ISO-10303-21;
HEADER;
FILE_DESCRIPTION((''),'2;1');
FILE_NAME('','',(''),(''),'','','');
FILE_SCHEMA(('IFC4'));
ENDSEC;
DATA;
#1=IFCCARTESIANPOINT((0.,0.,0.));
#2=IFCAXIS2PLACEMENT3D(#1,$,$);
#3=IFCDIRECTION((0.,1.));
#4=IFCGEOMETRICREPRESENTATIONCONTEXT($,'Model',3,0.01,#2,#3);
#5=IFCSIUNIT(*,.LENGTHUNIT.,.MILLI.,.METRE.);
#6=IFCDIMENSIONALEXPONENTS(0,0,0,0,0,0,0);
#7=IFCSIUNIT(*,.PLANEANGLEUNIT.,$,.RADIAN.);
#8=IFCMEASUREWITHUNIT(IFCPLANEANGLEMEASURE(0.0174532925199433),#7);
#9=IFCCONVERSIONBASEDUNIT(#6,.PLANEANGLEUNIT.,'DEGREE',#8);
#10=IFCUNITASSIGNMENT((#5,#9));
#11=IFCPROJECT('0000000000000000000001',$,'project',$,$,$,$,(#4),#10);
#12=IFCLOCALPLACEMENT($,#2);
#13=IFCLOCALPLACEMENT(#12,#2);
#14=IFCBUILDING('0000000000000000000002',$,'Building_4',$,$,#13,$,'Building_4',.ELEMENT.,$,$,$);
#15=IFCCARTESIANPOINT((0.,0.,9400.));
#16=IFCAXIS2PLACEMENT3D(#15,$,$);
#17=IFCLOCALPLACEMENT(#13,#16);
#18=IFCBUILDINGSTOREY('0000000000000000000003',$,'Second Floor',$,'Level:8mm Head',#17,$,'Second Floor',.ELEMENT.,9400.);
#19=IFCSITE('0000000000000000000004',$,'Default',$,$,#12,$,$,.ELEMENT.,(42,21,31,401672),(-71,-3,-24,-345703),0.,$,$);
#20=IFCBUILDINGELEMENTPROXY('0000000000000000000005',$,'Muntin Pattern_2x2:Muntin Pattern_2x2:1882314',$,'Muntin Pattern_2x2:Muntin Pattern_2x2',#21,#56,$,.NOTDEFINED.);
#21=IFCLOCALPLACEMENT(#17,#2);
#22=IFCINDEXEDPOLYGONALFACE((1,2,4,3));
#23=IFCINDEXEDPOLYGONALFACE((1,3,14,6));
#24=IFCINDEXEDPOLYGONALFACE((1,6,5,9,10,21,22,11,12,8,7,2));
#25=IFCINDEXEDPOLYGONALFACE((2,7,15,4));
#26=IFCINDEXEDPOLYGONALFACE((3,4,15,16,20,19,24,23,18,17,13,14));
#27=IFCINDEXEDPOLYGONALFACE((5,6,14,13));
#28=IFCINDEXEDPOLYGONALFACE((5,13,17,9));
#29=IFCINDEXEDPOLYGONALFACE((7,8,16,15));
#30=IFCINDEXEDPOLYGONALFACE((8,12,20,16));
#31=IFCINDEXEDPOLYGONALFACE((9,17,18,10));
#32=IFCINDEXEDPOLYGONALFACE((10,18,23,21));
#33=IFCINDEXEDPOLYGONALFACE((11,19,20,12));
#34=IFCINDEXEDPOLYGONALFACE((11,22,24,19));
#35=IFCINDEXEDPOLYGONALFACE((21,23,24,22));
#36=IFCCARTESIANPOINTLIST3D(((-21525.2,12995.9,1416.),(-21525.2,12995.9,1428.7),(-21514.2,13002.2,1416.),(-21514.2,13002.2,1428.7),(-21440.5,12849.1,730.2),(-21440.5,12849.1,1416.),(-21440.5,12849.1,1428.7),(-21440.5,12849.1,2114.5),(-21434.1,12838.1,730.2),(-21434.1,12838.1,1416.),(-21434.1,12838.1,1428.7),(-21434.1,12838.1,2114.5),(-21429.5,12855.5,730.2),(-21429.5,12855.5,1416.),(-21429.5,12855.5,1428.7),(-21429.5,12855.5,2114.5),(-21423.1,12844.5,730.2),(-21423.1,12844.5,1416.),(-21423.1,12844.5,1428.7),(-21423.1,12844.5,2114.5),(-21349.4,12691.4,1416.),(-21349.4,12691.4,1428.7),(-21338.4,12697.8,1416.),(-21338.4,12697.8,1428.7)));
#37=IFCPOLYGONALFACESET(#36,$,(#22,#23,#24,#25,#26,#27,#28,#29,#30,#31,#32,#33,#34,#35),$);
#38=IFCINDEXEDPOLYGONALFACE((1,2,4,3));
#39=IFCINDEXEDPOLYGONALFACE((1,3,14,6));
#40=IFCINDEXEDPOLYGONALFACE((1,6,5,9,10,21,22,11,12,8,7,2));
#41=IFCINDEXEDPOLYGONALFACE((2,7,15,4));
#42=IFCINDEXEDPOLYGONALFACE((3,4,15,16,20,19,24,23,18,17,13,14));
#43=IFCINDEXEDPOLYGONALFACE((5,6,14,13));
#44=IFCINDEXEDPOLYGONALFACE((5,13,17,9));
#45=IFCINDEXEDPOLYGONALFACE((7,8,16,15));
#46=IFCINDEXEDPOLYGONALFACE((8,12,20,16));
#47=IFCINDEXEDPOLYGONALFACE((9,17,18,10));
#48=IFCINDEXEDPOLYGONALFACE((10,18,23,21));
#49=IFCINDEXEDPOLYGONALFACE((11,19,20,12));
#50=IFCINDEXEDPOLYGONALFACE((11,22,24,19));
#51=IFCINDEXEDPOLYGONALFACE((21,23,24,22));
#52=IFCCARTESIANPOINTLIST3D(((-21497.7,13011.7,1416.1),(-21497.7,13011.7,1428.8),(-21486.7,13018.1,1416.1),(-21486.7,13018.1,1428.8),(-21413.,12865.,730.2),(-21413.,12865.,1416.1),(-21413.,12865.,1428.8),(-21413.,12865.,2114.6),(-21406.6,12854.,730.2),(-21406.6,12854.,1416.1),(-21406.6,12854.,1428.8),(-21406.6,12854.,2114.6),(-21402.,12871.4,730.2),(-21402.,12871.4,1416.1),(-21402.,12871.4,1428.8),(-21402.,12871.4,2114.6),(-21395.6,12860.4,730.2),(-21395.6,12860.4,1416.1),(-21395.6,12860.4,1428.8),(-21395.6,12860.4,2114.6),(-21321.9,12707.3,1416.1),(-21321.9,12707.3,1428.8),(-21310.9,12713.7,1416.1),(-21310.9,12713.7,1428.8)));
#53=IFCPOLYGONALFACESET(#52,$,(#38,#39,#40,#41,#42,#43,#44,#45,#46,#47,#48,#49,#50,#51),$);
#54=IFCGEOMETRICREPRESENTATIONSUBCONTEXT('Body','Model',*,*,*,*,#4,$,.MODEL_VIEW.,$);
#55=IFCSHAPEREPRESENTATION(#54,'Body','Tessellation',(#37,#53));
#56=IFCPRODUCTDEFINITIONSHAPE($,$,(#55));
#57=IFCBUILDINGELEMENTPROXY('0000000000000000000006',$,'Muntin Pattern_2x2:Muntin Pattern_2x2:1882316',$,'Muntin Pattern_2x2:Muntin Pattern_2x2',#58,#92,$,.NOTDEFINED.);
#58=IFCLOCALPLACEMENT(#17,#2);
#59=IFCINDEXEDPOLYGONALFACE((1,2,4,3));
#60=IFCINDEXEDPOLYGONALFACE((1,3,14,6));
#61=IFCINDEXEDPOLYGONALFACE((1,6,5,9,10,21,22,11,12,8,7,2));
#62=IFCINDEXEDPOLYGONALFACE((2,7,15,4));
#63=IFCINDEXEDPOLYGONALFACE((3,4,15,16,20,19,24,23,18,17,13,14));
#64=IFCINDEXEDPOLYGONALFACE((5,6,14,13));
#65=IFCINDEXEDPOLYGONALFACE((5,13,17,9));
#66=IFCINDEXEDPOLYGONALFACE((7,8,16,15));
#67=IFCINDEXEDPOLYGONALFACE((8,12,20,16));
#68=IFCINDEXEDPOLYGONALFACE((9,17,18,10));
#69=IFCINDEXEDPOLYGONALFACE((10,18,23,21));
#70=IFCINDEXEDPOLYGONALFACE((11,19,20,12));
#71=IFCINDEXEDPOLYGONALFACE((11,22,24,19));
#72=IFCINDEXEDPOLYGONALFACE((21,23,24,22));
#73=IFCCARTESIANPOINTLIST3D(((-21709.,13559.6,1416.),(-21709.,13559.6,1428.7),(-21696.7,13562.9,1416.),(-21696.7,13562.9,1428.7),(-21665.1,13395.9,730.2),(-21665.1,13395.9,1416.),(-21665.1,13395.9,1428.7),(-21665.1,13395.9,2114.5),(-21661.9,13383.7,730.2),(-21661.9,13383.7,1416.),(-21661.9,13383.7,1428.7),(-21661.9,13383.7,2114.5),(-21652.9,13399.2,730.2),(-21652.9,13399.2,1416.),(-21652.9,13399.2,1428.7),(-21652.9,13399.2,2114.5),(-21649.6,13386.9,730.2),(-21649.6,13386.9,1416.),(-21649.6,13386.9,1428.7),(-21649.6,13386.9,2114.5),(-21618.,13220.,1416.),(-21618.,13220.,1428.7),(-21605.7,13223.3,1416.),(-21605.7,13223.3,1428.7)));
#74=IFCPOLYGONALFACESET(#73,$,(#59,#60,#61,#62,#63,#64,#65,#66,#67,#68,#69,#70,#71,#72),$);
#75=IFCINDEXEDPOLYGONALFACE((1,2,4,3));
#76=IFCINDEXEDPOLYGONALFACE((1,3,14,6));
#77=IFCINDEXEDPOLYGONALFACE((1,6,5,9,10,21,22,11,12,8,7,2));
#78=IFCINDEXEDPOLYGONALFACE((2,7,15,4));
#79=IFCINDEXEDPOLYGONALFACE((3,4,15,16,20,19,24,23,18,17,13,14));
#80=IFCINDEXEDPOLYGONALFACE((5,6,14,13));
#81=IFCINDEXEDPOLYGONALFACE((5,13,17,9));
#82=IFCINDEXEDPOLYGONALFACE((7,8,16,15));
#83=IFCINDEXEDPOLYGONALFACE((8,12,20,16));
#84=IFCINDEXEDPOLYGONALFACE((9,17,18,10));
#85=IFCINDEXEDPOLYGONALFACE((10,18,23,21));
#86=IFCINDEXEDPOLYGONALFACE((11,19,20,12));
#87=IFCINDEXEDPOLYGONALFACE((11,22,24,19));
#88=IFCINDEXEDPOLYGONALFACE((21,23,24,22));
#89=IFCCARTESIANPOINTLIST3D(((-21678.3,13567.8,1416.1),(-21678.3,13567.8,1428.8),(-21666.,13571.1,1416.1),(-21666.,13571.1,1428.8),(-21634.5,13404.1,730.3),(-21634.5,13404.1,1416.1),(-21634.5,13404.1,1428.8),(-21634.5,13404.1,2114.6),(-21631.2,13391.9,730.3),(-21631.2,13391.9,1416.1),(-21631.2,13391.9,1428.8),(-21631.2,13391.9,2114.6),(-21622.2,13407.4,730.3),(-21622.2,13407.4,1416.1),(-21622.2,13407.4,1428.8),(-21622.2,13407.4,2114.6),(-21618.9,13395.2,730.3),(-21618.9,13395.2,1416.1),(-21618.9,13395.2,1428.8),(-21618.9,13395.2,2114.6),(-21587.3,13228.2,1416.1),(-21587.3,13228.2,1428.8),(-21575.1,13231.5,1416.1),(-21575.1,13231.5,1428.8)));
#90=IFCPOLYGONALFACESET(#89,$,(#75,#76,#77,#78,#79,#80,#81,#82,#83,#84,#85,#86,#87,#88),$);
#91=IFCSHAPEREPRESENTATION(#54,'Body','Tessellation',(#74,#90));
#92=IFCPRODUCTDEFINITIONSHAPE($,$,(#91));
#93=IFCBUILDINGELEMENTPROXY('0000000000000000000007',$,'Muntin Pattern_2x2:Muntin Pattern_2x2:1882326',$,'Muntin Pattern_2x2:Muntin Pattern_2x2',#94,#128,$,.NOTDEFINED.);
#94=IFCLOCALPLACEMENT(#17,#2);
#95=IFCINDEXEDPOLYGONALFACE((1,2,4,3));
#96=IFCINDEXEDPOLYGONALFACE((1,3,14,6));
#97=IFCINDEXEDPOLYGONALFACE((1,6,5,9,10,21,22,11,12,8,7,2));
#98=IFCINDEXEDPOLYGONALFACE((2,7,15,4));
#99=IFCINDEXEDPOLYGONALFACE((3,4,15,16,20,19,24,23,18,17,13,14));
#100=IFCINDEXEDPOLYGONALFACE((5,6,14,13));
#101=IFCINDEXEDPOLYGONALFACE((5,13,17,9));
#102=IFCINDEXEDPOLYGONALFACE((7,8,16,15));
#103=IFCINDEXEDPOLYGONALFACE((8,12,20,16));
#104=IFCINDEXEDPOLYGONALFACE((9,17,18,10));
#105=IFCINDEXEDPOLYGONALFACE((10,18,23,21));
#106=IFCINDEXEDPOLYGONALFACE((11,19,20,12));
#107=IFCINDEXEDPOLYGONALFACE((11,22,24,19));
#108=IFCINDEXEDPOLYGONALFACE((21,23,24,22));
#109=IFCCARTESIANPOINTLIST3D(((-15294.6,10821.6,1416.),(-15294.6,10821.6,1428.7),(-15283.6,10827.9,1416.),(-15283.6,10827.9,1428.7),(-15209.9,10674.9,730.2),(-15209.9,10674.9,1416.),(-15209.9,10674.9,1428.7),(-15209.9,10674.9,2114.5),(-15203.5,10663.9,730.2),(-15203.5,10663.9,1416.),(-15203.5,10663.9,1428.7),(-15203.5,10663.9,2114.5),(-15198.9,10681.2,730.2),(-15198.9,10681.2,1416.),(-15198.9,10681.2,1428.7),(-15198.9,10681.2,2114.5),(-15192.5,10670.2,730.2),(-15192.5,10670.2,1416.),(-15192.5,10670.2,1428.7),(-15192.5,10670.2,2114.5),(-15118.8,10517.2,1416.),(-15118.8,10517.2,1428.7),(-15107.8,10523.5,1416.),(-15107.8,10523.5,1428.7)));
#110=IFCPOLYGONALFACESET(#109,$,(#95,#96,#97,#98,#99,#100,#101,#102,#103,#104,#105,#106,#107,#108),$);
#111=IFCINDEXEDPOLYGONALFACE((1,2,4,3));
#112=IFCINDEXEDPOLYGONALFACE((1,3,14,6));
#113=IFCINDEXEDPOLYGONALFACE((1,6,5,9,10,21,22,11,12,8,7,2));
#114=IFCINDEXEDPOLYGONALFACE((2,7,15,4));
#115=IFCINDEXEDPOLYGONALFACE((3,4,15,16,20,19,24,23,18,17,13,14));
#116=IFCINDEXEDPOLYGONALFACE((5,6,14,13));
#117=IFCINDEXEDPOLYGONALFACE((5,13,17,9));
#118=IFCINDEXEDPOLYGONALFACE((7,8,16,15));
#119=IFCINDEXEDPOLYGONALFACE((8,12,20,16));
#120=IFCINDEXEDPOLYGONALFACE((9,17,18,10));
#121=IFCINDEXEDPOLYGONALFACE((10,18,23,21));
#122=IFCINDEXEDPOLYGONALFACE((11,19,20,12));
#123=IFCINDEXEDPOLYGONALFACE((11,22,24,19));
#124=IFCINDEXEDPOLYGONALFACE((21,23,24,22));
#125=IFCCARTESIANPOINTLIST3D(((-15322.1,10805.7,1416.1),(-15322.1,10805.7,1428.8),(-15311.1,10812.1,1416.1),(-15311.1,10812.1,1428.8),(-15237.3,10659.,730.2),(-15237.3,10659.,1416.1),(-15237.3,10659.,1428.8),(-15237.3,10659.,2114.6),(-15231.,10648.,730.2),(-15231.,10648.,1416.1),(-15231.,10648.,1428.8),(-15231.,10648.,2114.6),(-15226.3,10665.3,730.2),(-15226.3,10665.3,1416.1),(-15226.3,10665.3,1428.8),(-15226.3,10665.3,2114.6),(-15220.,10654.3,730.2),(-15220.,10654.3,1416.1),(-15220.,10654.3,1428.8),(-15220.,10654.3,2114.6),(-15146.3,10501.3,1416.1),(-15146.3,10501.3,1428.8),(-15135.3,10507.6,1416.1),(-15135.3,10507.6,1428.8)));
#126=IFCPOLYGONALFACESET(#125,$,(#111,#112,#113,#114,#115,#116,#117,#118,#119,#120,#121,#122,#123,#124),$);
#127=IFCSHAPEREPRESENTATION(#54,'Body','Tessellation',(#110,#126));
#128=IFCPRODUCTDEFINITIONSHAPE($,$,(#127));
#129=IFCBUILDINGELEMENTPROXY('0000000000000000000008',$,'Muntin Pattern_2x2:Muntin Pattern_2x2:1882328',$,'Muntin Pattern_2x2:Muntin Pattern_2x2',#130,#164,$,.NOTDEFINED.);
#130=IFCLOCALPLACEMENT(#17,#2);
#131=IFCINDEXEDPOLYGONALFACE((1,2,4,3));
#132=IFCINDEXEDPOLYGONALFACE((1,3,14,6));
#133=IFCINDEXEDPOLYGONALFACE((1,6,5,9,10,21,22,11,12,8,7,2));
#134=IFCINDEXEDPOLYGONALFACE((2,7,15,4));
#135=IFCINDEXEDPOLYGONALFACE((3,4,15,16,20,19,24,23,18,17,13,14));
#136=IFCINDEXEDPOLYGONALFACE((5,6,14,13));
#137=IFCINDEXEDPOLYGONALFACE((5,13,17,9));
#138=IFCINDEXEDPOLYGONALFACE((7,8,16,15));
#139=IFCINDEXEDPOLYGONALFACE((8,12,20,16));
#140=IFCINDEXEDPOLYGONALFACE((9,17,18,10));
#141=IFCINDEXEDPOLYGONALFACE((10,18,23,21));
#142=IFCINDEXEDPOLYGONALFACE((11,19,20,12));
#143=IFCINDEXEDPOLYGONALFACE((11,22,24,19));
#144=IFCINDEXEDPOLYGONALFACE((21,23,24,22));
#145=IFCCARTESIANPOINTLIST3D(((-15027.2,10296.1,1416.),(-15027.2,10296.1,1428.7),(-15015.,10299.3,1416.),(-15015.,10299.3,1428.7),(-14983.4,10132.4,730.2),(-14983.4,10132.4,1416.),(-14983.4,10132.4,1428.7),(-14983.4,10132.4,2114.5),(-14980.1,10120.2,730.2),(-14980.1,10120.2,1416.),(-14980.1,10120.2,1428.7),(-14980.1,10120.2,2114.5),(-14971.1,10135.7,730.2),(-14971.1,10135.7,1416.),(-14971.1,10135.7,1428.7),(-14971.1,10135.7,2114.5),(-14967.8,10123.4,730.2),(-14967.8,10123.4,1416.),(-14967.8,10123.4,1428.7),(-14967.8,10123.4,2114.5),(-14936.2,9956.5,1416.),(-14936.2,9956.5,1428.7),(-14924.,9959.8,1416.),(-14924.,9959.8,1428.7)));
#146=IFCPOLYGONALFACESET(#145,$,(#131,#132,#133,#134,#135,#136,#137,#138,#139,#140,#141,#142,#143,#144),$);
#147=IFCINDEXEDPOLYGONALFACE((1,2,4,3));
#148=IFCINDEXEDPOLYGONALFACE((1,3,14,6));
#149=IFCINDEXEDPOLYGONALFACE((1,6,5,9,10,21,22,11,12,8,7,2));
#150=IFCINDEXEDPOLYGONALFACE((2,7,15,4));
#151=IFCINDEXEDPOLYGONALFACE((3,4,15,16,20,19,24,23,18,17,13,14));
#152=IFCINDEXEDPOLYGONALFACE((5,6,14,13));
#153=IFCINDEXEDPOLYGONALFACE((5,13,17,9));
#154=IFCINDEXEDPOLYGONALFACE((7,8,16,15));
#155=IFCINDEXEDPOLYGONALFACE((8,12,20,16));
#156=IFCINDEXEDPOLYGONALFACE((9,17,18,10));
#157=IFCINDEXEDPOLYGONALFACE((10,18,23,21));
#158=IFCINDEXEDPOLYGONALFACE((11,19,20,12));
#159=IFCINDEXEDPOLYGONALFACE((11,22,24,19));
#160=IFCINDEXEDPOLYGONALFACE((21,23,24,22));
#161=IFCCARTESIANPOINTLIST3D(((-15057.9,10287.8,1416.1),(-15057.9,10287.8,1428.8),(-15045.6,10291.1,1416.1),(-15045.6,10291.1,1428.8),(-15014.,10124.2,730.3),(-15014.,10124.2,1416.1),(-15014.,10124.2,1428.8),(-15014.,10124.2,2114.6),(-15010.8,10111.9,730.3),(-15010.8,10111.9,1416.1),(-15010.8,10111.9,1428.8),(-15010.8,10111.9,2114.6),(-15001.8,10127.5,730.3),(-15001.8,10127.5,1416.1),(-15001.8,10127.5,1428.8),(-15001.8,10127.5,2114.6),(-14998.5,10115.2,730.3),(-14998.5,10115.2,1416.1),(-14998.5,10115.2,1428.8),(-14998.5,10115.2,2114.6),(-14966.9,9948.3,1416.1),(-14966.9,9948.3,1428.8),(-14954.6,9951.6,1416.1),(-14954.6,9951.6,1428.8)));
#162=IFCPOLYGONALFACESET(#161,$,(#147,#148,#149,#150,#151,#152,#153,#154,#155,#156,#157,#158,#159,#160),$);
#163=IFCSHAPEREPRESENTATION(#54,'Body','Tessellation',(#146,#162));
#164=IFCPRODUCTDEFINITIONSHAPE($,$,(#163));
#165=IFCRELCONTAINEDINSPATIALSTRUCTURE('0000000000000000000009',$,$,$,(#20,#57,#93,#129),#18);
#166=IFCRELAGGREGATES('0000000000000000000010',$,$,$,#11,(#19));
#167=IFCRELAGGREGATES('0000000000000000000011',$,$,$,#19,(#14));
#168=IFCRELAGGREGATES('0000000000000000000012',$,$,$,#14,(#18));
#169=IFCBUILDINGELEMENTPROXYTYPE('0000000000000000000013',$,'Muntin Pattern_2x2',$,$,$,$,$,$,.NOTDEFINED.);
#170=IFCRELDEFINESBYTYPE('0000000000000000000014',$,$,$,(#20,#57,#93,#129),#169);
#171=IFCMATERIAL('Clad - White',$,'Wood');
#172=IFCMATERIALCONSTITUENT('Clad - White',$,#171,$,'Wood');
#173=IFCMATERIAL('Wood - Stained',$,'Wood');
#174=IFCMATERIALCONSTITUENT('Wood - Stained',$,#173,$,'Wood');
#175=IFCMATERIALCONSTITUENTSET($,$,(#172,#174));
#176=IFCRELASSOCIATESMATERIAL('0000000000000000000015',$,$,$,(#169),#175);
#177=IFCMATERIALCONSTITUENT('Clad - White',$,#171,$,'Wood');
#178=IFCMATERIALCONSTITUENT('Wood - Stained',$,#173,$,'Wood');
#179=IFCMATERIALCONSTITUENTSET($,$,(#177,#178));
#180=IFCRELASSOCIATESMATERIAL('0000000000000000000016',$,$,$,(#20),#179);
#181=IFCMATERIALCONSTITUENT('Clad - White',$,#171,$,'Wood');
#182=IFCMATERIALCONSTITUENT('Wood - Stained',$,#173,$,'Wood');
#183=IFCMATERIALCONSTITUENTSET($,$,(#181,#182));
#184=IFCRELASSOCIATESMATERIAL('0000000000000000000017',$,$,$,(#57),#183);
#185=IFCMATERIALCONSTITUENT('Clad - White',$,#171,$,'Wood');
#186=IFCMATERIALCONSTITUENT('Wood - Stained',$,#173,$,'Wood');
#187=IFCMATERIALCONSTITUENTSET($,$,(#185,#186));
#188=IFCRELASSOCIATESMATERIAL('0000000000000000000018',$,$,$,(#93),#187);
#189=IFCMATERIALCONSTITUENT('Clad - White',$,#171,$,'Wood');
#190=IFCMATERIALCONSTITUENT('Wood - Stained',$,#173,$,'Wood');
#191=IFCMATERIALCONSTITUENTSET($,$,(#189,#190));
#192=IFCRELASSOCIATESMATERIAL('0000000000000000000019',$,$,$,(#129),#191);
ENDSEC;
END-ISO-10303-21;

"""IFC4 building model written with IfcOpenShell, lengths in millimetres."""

from ifc_helpers import new_model, entity, si_unit, converted_unit, direction, frame, origin, place, context, subcontext, project, spatial, indexed_curve, outline, extrude, source, transform, mapped, material, constituent, constituent_set, type_object, type_shapes, element, save


model = new_model("IFC4")

# Units and contexts
model_context = context("Model", 3, precision=0.01, world=origin(), true_north=direction((0.0, 1.0)))
body_context = subcontext(model_context, "Body", "Model", "MODEL_VIEW")
ifc_project = project(units=[si_unit("LENGTHUNIT", "METRE", prefix="MILLI"), converted_unit("PLANEANGLEUNIT", "DEGREE", entity("IfcPlaneAngleMeasure", 0.0174532925199433), si_unit("PLANEANGLEUNIT", "RADIAN"), dimensions=[0, 0, 0, 0, 0, 0, 0])], contexts=[model_context])

# Site, building, storey
site_placement = place(None, origin())
site = spatial("IfcSite", under=ifc_project, at=site_placement, Name="Default", CompositionType="ELEMENT", RefLatitude=(42, 21, 31, 401672), RefLongitude=(-71, -3, -24, -345703), RefElevation=0.0)
building_placement = place(site_placement, origin())
building = spatial("IfcBuilding", under=site, at=building_placement, Name="Building_4", LongName="Building_4", CompositionType="ELEMENT")
storey_placement = place(building_placement, frame((0.0, 0.0, 9400.0)))
storey = spatial("IfcBuildingStorey", under=building, at=storey_placement, Name="Second Floor", ObjectType="Level:8mm Head", LongName="Second Floor", CompositionType="ELEMENT", Elevation=9400.0)

# Building element proxies
ifc_material_1 = material(Name="Clad - White", Category="Wood")
ifc_material_2 = material(Name="Wood - Stained", Category="Wood")
ifc_constituent_1 = constituent(ifc_material_1, Name="Clad - White", Category="Wood")
ifc_constituent_2 = constituent(ifc_material_2, Name="Wood - Stained", Category="Wood")
ifc_constituent_set_1 = constituent_set(constituents=[ifc_constituent_1, ifc_constituent_2])
building_element_proxy_type_1 = type_object("IfcBuildingElementProxyType", Name="Muntin Pattern_2x2", PredefinedType="NOTDEFINED", material=ifc_constituent_set_1)
shared_shape_1 = source(origin(), body_context, "Body", "SweptSolid", [
    extrude(outline(indexed_curve([(6.4, -6.4), (692.1, -6.4), (692.1, 6.3), (6.4, 6.3), (6.4, 175.8), (-6.3, 175.8), (-6.3, 6.3), (-692.2, 6.3), (-692.2, -6.4), (-6.3, -6.4), (-6.3, -175.8), (6.4, -175.8), (6.4, -6.4)], self_intersect=False)), frame((0.0, 9.5, 692.1), z_axis=(0.0, 1.0, 0.0), x_axis=(0.0, 0.0, 1.0)), (0.0, 0.0, 1.0), 12.7),
    extrude(outline(indexed_curve([(6.4, -6.4), (692.1, -6.4), (692.1, 6.3), (6.4, 6.3), (6.4, 175.8), (-6.3, 175.8), (-6.3, 6.3), (-692.2, 6.3), (-692.2, -6.4), (-6.3, -6.4), (-6.3, -175.8), (6.4, -175.8), (6.4, -6.4)], self_intersect=False)), frame((0.0, -22.2, 692.2), z_axis=(0.0, 1.0, 0.0), x_axis=(0.0, 0.0, 1.0)), (0.0, 0.0, 1.0), 12.7),
])
type_shapes(building_element_proxy_type_1, [shared_shape_1])
ifc_constituent_3 = constituent(ifc_material_1, Name="Clad - White", Category="Wood")
ifc_constituent_4 = constituent(ifc_material_2, Name="Wood - Stained", Category="Wood")
ifc_constituent_set_2 = constituent_set(constituents=[ifc_constituent_3, ifc_constituent_4])
proxy_1_placement = place(storey_placement, frame((-21418.0, 12854.8, 730.2), z_axis=(0.0, 0.0, 1.0), x_axis=(-0.5, 0.866025, 0.0)))
element("IfcBuildingElementProxy", 1, at=proxy_1_placement, inside=storey, type_object=building_element_proxy_type_1, material=ifc_constituent_set_2, Name="Muntin Pattern_2x2:Muntin Pattern_2x2:1882314", ObjectType="Muntin Pattern_2x2:Muntin Pattern_2x2", PredefinedType="NOTDEFINED", context=body_context, shape_type="MappedRepresentation", body=[
    mapped(shared_shape_1, transform((0.0, 0.0, 0.0), scale=1.0)),
])
ifc_constituent_5 = constituent(ifc_material_1, Name="Clad - White", Category="Wood")
ifc_constituent_6 = constituent(ifc_material_2, Name="Wood - Stained", Category="Wood")
ifc_constituent_set_3 = constituent_set(constituents=[ifc_constituent_5, ifc_constituent_6])
proxy_2_placement = place(storey_placement, frame((-21642.0, 13395.5, 730.3), z_axis=(0.0, 0.0, 1.0), x_axis=(-0.258819, 0.965926, 0.0)))
element("IfcBuildingElementProxy", 2, at=proxy_2_placement, inside=storey, type_object=building_element_proxy_type_1, material=ifc_constituent_set_3, Name="Muntin Pattern_2x2:Muntin Pattern_2x2:1882316", ObjectType="Muntin Pattern_2x2:Muntin Pattern_2x2", PredefinedType="NOTDEFINED", context=body_context, shape_type="MappedRepresentation", body=[
    mapped(shared_shape_1, transform((0.0, 0.0, 0.0), scale=1.0)),
])
ifc_constituent_7 = constituent(ifc_material_1, Name="Clad - White", Category="Wood")
ifc_constituent_8 = constituent(ifc_material_2, Name="Wood - Stained", Category="Wood")
ifc_constituent_set_4 = constituent_set(constituents=[ifc_constituent_7, ifc_constituent_8])
proxy_3_placement = place(storey_placement, frame((-15214.9, 10664.6, 730.2), z_axis=(0.0, 0.0, 1.0), x_axis=(0.5, -0.866025, 0.0)))
element("IfcBuildingElementProxy", 3, at=proxy_3_placement, inside=storey, type_object=building_element_proxy_type_1, material=ifc_constituent_set_4, Name="Muntin Pattern_2x2:Muntin Pattern_2x2:1882326", ObjectType="Muntin Pattern_2x2:Muntin Pattern_2x2", PredefinedType="NOTDEFINED", context=body_context, shape_type="MappedRepresentation", body=[
    mapped(shared_shape_1, transform((0.0, 0.0, 0.0), scale=1.0)),
])
ifc_constituent_9 = constituent(ifc_material_1, Name="Clad - White", Category="Wood")
ifc_constituent_10 = constituent(ifc_material_2, Name="Wood - Stained", Category="Wood")
ifc_constituent_set_5 = constituent_set(constituents=[ifc_constituent_9, ifc_constituent_10])
proxy_4_placement = place(storey_placement, frame((-14990.9, 10123.8, 730.3), z_axis=(0.0, 0.0, 1.0), x_axis=(0.258819, -0.965926, 0.0)))
element("IfcBuildingElementProxy", 4, at=proxy_4_placement, inside=storey, type_object=building_element_proxy_type_1, material=ifc_constituent_set_5, Name="Muntin Pattern_2x2:Muntin Pattern_2x2:1882328", ObjectType="Muntin Pattern_2x2:Muntin Pattern_2x2", PredefinedType="NOTDEFINED", context=body_context, shape_type="MappedRepresentation", body=[
    mapped(shared_shape_1, transform((0.0, 0.0, 0.0), scale=1.0)),
])

save(model, "model.ifc")
